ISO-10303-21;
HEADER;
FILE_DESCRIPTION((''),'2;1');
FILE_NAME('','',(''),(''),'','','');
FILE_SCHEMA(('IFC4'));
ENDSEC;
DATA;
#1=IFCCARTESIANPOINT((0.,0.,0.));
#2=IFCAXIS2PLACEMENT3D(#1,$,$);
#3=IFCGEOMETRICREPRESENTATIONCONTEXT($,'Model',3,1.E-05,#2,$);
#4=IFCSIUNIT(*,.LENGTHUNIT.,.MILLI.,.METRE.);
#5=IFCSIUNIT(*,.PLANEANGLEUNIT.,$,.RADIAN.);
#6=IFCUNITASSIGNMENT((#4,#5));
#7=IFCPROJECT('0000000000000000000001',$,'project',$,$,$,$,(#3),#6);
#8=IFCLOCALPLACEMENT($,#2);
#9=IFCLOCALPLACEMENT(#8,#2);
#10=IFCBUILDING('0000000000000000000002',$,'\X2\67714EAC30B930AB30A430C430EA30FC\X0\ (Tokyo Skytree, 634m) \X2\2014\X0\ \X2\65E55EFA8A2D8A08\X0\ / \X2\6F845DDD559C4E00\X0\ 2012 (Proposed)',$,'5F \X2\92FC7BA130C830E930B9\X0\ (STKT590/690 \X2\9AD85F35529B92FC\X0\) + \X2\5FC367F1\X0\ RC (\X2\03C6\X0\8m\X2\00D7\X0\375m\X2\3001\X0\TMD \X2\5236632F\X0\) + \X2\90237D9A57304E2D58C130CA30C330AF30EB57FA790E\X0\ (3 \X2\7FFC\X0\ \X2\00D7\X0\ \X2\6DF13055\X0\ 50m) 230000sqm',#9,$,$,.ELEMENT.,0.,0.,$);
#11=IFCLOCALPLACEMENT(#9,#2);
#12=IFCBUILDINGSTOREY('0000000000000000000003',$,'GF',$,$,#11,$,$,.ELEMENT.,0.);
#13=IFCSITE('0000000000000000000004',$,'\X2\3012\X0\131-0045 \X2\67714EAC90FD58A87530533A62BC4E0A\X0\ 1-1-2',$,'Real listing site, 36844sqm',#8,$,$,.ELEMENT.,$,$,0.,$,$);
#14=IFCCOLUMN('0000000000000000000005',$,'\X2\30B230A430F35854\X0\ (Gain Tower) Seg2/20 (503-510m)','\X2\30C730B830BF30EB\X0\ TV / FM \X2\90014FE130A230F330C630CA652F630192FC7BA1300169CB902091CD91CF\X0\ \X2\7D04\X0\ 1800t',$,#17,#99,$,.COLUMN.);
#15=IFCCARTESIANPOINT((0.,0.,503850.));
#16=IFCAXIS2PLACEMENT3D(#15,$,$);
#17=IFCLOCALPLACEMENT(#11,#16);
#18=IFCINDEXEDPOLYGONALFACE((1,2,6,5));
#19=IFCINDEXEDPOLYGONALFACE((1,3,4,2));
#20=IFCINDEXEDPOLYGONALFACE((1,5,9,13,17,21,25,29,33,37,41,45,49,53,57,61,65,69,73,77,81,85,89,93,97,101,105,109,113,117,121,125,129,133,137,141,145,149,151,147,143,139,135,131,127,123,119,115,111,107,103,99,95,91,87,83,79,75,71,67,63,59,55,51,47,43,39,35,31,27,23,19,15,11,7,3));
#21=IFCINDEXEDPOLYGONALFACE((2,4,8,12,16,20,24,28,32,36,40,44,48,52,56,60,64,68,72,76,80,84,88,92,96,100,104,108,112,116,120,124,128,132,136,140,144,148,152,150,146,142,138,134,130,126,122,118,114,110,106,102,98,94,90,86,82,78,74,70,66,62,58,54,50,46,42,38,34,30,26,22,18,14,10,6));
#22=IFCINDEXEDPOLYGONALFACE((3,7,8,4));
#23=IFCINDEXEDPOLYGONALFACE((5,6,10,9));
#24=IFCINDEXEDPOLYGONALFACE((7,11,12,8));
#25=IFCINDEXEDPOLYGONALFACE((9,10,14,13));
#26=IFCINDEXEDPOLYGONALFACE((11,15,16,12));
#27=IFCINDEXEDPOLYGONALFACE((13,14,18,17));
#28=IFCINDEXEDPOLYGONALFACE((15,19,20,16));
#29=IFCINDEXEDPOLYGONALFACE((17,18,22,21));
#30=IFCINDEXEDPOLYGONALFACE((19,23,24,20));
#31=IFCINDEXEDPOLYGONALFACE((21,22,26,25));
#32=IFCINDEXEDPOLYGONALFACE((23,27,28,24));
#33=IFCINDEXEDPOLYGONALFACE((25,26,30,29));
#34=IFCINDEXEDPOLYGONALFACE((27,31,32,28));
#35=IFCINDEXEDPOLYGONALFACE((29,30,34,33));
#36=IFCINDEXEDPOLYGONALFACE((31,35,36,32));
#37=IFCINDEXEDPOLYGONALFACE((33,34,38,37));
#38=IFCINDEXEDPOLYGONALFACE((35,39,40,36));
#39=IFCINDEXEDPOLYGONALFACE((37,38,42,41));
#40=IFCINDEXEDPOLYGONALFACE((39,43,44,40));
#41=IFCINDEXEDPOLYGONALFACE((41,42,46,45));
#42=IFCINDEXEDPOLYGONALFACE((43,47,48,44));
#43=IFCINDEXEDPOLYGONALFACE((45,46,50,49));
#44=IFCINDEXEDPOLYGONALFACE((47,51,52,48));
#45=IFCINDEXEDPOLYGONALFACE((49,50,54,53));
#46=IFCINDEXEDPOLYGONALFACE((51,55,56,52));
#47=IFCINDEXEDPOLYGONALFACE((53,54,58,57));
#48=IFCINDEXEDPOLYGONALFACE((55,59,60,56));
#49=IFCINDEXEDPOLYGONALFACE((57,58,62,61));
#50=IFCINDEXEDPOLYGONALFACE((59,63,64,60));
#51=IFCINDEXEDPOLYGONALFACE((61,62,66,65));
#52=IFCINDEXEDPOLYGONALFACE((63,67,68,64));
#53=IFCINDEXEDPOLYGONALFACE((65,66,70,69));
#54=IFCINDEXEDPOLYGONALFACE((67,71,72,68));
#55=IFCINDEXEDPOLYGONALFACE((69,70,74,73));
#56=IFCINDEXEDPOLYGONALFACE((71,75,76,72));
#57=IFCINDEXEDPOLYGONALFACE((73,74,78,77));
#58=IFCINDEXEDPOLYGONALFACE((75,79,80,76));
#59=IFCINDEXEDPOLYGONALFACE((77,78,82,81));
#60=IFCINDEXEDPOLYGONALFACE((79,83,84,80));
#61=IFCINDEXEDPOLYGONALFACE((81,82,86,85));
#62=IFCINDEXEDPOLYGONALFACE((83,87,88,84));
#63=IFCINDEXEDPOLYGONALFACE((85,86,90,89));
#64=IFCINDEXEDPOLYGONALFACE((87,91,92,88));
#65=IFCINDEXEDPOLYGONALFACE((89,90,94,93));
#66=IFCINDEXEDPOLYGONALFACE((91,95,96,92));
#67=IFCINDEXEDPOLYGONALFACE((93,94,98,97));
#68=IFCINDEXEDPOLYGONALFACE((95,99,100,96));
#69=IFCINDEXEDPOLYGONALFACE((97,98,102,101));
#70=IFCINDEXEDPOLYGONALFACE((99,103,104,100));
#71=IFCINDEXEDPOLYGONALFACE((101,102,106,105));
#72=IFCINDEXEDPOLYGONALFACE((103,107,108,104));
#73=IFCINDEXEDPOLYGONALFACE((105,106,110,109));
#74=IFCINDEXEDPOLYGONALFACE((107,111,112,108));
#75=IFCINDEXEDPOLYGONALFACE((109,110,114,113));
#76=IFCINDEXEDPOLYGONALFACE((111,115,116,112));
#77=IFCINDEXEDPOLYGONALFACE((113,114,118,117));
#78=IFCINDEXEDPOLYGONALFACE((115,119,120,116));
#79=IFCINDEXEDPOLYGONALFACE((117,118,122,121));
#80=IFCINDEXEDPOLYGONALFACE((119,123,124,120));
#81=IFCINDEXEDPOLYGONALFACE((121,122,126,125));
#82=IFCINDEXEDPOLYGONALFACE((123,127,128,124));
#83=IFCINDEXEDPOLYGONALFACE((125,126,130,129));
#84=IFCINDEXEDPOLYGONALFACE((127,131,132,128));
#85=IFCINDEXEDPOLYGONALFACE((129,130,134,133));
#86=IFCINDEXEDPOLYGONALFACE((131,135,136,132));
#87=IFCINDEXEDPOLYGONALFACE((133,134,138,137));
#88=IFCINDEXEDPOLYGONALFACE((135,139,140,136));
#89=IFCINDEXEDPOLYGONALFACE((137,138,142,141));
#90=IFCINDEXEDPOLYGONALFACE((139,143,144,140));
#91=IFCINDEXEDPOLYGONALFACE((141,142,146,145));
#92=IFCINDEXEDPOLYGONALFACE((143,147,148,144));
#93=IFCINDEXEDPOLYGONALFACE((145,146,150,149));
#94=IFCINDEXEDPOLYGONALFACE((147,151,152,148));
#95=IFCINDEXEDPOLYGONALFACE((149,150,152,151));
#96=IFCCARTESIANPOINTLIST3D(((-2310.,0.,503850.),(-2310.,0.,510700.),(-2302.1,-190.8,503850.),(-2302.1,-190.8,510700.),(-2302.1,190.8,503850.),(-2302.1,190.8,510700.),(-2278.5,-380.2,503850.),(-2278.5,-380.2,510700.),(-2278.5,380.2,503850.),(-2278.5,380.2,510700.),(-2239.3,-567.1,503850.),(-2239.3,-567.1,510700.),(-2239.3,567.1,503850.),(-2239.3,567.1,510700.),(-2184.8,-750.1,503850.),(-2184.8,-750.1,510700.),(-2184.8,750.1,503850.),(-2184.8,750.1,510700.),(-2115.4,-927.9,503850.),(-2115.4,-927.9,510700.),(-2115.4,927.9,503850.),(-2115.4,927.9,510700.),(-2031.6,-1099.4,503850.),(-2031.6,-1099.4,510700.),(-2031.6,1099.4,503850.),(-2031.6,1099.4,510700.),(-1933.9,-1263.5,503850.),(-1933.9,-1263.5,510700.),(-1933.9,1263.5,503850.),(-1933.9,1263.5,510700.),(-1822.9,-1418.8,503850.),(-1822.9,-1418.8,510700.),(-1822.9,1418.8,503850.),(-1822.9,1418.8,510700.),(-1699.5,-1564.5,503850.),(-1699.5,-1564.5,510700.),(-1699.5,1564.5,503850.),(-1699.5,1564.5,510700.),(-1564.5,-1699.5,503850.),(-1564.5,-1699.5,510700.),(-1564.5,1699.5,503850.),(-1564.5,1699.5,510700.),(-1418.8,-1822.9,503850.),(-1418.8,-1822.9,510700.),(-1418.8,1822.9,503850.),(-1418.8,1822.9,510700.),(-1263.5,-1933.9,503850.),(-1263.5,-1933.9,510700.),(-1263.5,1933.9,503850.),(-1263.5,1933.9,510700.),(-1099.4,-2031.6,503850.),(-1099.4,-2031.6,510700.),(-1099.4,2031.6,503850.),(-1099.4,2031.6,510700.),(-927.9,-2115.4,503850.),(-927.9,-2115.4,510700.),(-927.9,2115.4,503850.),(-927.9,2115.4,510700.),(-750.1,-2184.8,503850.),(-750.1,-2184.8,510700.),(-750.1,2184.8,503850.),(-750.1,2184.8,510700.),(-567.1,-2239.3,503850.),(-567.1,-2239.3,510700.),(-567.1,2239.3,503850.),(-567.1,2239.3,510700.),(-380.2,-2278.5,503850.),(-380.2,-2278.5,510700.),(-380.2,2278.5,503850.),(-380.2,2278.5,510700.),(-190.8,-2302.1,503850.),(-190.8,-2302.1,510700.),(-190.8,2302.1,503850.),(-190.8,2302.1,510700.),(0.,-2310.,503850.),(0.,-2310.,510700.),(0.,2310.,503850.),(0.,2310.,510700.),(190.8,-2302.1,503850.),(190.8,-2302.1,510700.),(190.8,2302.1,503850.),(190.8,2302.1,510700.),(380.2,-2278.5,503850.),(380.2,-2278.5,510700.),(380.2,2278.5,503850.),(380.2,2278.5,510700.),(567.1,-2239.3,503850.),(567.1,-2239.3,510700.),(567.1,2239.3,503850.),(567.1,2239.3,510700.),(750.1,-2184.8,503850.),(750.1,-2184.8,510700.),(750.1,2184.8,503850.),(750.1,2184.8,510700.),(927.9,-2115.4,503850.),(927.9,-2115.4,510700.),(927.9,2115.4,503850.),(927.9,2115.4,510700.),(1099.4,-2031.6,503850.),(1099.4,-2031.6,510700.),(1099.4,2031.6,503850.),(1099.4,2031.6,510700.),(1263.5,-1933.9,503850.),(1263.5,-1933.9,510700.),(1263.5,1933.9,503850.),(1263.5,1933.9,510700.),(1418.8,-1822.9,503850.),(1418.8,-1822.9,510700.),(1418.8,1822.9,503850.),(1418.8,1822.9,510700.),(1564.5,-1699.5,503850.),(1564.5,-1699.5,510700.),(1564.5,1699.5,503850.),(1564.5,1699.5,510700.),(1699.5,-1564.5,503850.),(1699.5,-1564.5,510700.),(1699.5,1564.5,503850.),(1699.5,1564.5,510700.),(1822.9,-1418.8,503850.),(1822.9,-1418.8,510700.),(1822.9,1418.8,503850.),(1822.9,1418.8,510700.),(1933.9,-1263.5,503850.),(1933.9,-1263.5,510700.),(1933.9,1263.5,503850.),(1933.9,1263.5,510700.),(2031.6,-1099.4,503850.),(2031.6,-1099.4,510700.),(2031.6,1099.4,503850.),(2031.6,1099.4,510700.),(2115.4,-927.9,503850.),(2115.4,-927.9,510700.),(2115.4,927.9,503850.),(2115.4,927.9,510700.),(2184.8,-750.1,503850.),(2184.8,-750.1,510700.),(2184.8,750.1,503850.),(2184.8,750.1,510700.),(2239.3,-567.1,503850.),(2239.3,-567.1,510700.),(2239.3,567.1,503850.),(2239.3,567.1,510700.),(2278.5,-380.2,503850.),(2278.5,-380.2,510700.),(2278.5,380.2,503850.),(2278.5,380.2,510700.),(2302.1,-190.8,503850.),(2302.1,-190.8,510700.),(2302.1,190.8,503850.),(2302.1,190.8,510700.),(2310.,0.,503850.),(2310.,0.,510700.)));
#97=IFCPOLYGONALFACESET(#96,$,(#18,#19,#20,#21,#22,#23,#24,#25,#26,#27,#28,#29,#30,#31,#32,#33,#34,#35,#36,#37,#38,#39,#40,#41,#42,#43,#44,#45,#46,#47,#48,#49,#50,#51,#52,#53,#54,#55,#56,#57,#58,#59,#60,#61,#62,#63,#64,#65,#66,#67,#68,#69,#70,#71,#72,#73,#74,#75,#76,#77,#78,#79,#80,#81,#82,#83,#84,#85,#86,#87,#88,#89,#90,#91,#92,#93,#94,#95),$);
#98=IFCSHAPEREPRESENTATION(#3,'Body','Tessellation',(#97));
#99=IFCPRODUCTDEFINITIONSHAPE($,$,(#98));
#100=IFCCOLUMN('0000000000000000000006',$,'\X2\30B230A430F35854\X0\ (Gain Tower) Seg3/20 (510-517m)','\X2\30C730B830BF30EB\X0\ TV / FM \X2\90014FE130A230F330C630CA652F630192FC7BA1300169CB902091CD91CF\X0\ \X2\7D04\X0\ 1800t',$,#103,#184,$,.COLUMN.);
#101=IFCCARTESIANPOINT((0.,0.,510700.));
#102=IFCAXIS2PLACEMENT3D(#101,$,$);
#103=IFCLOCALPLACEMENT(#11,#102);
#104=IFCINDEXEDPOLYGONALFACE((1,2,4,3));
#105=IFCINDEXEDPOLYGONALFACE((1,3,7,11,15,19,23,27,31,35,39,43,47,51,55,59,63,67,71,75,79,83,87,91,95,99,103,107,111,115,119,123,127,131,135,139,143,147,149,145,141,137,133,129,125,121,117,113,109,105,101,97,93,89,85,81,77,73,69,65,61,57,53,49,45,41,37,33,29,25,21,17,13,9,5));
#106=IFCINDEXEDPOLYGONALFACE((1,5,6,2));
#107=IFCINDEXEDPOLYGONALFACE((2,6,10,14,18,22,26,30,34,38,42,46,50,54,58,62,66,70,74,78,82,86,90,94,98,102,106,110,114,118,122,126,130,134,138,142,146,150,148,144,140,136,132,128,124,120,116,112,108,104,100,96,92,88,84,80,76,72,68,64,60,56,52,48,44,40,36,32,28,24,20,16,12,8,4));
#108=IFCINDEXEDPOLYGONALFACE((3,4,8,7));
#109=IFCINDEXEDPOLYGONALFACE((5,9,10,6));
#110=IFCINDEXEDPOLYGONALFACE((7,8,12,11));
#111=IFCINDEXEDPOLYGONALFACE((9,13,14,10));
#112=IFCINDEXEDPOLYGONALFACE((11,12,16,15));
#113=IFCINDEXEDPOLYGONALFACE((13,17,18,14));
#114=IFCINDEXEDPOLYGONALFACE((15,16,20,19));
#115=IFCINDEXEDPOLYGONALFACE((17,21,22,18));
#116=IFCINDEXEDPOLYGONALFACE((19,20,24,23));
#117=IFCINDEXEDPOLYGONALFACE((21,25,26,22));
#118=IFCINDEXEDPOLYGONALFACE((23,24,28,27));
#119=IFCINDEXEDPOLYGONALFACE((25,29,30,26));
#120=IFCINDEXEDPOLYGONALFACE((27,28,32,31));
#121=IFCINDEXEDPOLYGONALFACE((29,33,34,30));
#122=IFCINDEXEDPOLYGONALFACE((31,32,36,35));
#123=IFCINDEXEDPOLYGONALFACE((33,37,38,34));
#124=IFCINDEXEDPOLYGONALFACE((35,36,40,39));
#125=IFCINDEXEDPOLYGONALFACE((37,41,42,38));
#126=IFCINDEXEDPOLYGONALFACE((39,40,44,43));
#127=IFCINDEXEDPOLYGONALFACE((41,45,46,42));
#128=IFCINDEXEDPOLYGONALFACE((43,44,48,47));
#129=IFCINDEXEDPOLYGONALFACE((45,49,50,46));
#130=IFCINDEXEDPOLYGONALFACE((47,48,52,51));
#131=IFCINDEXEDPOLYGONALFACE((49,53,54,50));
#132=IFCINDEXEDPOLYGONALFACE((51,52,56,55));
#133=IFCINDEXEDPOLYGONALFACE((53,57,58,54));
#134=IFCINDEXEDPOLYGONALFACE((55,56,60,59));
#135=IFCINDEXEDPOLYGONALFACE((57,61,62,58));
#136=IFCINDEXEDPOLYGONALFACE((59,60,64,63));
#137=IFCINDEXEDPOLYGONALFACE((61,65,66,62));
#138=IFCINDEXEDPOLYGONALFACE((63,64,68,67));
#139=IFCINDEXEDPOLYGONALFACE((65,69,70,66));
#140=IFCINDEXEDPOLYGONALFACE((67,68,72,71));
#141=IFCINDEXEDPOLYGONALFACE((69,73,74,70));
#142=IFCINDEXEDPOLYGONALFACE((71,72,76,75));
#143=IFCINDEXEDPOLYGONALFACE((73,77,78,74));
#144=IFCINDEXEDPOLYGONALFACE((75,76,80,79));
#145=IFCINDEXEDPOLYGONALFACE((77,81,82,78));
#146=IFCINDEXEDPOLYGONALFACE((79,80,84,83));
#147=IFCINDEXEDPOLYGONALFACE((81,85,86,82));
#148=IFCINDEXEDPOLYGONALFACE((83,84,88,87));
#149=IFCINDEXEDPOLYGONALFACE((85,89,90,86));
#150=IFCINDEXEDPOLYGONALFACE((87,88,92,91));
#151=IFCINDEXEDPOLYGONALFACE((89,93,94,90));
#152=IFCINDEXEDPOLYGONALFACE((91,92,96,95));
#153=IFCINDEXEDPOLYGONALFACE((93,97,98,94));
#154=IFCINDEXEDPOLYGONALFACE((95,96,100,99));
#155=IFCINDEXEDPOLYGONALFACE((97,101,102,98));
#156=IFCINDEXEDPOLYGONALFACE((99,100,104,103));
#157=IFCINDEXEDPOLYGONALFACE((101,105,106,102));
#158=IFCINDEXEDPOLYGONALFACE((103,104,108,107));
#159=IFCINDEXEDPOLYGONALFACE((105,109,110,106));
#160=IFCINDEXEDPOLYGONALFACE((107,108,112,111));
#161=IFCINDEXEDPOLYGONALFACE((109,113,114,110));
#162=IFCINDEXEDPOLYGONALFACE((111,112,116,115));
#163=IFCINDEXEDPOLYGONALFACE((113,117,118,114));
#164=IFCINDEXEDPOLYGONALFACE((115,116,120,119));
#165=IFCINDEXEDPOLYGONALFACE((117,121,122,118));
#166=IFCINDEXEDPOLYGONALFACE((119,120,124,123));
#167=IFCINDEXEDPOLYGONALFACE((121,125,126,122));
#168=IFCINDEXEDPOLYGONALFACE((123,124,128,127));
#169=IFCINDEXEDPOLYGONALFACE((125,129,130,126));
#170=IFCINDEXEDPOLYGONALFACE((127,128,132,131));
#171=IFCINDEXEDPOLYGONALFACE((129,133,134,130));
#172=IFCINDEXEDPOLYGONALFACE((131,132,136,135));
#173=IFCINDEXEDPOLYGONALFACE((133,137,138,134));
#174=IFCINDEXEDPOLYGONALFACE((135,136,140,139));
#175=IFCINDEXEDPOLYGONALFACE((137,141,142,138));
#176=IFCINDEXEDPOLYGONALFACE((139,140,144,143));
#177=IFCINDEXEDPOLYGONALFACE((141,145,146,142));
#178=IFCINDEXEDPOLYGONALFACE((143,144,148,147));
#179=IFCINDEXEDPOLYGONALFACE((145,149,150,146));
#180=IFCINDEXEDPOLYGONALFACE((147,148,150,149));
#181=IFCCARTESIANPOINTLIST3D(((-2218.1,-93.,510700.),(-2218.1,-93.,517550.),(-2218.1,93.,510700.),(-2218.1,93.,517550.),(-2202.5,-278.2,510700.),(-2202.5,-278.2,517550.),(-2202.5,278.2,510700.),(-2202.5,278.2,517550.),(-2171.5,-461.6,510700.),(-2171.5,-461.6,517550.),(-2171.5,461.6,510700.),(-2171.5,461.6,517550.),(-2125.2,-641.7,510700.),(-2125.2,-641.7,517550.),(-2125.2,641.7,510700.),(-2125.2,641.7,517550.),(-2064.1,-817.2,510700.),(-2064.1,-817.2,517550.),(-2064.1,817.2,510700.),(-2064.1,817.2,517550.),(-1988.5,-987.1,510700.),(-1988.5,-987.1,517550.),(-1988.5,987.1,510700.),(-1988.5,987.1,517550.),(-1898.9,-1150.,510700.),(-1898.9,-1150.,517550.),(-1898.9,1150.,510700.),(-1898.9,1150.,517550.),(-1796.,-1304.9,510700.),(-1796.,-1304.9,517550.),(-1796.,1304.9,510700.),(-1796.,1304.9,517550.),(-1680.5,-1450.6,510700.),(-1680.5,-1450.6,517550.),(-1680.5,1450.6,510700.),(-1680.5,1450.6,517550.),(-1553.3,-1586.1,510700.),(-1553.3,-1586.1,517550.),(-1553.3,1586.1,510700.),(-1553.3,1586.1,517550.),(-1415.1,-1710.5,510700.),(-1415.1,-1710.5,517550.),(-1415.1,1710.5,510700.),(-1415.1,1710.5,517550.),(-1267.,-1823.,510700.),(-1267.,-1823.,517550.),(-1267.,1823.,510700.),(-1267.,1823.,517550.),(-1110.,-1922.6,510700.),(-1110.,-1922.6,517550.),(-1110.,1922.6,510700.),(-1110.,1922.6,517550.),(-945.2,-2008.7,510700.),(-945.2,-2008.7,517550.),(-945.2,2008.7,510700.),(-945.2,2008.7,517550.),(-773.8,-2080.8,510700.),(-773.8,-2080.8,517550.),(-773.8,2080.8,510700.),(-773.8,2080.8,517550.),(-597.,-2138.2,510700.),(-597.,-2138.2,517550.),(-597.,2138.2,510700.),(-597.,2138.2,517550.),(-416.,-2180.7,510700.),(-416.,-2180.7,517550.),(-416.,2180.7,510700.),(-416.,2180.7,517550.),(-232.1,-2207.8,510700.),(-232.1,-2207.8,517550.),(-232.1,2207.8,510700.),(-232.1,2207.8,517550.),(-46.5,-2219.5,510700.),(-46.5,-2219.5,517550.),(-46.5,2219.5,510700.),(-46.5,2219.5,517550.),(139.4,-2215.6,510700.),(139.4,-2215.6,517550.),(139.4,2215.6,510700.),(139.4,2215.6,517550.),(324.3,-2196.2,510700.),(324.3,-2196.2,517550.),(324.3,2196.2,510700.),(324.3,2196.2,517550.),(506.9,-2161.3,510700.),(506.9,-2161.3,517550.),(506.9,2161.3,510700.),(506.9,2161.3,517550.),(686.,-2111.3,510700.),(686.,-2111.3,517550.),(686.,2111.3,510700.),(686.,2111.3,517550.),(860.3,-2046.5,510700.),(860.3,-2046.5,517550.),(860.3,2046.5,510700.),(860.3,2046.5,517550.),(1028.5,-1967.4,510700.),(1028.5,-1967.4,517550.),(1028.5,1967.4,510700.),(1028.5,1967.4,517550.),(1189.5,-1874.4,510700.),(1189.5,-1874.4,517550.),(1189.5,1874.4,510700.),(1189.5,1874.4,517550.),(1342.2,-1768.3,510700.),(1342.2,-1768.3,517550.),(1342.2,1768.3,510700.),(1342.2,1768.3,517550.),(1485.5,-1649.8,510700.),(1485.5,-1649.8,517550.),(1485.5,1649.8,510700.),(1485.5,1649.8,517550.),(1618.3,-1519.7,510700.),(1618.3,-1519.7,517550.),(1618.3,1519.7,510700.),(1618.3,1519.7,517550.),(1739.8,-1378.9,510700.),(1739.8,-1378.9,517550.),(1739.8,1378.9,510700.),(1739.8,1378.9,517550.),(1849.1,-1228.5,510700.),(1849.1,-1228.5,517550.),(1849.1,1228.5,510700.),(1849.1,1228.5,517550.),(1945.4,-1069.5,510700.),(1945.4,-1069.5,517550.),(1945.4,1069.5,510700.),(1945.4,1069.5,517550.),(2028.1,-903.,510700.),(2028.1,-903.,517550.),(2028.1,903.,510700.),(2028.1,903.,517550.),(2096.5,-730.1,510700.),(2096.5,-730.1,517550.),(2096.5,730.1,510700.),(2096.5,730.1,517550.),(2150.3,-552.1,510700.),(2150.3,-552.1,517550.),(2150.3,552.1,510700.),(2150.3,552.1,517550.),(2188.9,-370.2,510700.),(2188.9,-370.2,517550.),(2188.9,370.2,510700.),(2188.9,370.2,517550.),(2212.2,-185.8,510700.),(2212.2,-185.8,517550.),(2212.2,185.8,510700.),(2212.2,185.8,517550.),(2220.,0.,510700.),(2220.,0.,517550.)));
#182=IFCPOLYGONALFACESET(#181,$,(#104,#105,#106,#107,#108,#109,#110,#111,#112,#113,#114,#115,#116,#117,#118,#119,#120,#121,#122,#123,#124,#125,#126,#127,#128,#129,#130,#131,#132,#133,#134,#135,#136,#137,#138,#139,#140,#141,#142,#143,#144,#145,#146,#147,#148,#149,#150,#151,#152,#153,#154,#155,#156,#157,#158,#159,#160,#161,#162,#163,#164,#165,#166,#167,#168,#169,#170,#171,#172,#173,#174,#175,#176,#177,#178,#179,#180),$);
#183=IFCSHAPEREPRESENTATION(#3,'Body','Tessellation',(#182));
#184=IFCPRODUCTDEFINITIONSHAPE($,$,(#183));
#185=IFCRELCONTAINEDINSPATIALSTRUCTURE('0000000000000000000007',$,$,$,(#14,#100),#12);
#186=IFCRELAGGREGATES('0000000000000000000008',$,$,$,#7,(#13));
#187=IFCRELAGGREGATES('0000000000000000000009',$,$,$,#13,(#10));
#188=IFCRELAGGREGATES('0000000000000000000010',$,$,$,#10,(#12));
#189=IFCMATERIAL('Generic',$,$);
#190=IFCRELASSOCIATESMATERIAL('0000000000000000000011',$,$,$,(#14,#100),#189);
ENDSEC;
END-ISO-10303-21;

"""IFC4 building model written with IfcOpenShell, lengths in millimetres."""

from ifc_helpers import new_model, si_unit, frame, origin, origin_2d, place, context, project, spatial, circle, extrude, material, element, save


model = new_model("IFC4")

# Units and contexts
model_context = context("Model", 3, precision=1e-05, world=origin())
ifc_project = project(units=[si_unit("LENGTHUNIT", "METRE", prefix="MILLI"), si_unit("PLANEANGLEUNIT", "RADIAN")], contexts=[model_context])

# Site, building, storey
site_placement = place(None, origin())
site = spatial("IfcSite", under=ifc_project, at=site_placement, Name="〒131-0045 東京都墨田区押上 1-1-2", ObjectType="Real listing site, 36844sqm", CompositionType="ELEMENT", RefElevation=0.0)
building_placement = place(site_placement, origin())
building = spatial("IfcBuilding", under=site, at=building_placement, Name="東京スカイツリー (Tokyo Skytree, 634m) — 日建設計 / 澄川喜一 2012 (Proposed)", ObjectType="5F 鋼管トラス (STKT590/690 高張力鋼) + 心柱 RC (φ8m×375m、TMD 制振) + 連続地中壁ナックル基礎 (3 翼 × 深さ 50m) 230000sqm", CompositionType="ELEMENT", ElevationOfRefHeight=0.0, ElevationOfTerrain=0.0)
storey_placement = place(building_placement, origin())
storey = spatial("IfcBuildingStorey", under=building, at=storey_placement, Name="GF", CompositionType="ELEMENT", Elevation=0.0)

# Columns
ifc_material = material(Name="Generic")
column_1_placement = place(storey_placement, frame((0.0, 0.0, 503850.0)))
element("IfcColumn", 1, at=column_1_placement, inside=storey, material=ifc_material, Name="ゲイン塔 (Gain Tower) Seg2/20 (503-510m)", Description="デジタル TV / FM 送信アンテナ支持鋼管、構造重量 約 1800t", PredefinedType="COLUMN", context=model_context, shape_type="SweptSolid", body=[
    extrude(circle(Radius=2310.0, at=origin_2d()), frame((0.0, 0.0, 503850.0)), (0.0, 0.0, 1.0), 6850.0),
])
column_2_placement = place(storey_placement, frame((0.0, 0.0, 510700.0)))
element("IfcColumn", 2, at=column_2_placement, inside=storey, material=ifc_material, Name="ゲイン塔 (Gain Tower) Seg3/20 (510-517m)", Description="デジタル TV / FM 送信アンテナ支持鋼管、構造重量 約 1800t", PredefinedType="COLUMN", context=model_context, shape_type="SweptSolid", body=[
    extrude(circle(Radius=2220.0, at=origin_2d()), frame((0.0, 0.0, 510700.0)), (0.0, 0.0, 1.0), 6850.0),
])

save(model, "model.ifc")
